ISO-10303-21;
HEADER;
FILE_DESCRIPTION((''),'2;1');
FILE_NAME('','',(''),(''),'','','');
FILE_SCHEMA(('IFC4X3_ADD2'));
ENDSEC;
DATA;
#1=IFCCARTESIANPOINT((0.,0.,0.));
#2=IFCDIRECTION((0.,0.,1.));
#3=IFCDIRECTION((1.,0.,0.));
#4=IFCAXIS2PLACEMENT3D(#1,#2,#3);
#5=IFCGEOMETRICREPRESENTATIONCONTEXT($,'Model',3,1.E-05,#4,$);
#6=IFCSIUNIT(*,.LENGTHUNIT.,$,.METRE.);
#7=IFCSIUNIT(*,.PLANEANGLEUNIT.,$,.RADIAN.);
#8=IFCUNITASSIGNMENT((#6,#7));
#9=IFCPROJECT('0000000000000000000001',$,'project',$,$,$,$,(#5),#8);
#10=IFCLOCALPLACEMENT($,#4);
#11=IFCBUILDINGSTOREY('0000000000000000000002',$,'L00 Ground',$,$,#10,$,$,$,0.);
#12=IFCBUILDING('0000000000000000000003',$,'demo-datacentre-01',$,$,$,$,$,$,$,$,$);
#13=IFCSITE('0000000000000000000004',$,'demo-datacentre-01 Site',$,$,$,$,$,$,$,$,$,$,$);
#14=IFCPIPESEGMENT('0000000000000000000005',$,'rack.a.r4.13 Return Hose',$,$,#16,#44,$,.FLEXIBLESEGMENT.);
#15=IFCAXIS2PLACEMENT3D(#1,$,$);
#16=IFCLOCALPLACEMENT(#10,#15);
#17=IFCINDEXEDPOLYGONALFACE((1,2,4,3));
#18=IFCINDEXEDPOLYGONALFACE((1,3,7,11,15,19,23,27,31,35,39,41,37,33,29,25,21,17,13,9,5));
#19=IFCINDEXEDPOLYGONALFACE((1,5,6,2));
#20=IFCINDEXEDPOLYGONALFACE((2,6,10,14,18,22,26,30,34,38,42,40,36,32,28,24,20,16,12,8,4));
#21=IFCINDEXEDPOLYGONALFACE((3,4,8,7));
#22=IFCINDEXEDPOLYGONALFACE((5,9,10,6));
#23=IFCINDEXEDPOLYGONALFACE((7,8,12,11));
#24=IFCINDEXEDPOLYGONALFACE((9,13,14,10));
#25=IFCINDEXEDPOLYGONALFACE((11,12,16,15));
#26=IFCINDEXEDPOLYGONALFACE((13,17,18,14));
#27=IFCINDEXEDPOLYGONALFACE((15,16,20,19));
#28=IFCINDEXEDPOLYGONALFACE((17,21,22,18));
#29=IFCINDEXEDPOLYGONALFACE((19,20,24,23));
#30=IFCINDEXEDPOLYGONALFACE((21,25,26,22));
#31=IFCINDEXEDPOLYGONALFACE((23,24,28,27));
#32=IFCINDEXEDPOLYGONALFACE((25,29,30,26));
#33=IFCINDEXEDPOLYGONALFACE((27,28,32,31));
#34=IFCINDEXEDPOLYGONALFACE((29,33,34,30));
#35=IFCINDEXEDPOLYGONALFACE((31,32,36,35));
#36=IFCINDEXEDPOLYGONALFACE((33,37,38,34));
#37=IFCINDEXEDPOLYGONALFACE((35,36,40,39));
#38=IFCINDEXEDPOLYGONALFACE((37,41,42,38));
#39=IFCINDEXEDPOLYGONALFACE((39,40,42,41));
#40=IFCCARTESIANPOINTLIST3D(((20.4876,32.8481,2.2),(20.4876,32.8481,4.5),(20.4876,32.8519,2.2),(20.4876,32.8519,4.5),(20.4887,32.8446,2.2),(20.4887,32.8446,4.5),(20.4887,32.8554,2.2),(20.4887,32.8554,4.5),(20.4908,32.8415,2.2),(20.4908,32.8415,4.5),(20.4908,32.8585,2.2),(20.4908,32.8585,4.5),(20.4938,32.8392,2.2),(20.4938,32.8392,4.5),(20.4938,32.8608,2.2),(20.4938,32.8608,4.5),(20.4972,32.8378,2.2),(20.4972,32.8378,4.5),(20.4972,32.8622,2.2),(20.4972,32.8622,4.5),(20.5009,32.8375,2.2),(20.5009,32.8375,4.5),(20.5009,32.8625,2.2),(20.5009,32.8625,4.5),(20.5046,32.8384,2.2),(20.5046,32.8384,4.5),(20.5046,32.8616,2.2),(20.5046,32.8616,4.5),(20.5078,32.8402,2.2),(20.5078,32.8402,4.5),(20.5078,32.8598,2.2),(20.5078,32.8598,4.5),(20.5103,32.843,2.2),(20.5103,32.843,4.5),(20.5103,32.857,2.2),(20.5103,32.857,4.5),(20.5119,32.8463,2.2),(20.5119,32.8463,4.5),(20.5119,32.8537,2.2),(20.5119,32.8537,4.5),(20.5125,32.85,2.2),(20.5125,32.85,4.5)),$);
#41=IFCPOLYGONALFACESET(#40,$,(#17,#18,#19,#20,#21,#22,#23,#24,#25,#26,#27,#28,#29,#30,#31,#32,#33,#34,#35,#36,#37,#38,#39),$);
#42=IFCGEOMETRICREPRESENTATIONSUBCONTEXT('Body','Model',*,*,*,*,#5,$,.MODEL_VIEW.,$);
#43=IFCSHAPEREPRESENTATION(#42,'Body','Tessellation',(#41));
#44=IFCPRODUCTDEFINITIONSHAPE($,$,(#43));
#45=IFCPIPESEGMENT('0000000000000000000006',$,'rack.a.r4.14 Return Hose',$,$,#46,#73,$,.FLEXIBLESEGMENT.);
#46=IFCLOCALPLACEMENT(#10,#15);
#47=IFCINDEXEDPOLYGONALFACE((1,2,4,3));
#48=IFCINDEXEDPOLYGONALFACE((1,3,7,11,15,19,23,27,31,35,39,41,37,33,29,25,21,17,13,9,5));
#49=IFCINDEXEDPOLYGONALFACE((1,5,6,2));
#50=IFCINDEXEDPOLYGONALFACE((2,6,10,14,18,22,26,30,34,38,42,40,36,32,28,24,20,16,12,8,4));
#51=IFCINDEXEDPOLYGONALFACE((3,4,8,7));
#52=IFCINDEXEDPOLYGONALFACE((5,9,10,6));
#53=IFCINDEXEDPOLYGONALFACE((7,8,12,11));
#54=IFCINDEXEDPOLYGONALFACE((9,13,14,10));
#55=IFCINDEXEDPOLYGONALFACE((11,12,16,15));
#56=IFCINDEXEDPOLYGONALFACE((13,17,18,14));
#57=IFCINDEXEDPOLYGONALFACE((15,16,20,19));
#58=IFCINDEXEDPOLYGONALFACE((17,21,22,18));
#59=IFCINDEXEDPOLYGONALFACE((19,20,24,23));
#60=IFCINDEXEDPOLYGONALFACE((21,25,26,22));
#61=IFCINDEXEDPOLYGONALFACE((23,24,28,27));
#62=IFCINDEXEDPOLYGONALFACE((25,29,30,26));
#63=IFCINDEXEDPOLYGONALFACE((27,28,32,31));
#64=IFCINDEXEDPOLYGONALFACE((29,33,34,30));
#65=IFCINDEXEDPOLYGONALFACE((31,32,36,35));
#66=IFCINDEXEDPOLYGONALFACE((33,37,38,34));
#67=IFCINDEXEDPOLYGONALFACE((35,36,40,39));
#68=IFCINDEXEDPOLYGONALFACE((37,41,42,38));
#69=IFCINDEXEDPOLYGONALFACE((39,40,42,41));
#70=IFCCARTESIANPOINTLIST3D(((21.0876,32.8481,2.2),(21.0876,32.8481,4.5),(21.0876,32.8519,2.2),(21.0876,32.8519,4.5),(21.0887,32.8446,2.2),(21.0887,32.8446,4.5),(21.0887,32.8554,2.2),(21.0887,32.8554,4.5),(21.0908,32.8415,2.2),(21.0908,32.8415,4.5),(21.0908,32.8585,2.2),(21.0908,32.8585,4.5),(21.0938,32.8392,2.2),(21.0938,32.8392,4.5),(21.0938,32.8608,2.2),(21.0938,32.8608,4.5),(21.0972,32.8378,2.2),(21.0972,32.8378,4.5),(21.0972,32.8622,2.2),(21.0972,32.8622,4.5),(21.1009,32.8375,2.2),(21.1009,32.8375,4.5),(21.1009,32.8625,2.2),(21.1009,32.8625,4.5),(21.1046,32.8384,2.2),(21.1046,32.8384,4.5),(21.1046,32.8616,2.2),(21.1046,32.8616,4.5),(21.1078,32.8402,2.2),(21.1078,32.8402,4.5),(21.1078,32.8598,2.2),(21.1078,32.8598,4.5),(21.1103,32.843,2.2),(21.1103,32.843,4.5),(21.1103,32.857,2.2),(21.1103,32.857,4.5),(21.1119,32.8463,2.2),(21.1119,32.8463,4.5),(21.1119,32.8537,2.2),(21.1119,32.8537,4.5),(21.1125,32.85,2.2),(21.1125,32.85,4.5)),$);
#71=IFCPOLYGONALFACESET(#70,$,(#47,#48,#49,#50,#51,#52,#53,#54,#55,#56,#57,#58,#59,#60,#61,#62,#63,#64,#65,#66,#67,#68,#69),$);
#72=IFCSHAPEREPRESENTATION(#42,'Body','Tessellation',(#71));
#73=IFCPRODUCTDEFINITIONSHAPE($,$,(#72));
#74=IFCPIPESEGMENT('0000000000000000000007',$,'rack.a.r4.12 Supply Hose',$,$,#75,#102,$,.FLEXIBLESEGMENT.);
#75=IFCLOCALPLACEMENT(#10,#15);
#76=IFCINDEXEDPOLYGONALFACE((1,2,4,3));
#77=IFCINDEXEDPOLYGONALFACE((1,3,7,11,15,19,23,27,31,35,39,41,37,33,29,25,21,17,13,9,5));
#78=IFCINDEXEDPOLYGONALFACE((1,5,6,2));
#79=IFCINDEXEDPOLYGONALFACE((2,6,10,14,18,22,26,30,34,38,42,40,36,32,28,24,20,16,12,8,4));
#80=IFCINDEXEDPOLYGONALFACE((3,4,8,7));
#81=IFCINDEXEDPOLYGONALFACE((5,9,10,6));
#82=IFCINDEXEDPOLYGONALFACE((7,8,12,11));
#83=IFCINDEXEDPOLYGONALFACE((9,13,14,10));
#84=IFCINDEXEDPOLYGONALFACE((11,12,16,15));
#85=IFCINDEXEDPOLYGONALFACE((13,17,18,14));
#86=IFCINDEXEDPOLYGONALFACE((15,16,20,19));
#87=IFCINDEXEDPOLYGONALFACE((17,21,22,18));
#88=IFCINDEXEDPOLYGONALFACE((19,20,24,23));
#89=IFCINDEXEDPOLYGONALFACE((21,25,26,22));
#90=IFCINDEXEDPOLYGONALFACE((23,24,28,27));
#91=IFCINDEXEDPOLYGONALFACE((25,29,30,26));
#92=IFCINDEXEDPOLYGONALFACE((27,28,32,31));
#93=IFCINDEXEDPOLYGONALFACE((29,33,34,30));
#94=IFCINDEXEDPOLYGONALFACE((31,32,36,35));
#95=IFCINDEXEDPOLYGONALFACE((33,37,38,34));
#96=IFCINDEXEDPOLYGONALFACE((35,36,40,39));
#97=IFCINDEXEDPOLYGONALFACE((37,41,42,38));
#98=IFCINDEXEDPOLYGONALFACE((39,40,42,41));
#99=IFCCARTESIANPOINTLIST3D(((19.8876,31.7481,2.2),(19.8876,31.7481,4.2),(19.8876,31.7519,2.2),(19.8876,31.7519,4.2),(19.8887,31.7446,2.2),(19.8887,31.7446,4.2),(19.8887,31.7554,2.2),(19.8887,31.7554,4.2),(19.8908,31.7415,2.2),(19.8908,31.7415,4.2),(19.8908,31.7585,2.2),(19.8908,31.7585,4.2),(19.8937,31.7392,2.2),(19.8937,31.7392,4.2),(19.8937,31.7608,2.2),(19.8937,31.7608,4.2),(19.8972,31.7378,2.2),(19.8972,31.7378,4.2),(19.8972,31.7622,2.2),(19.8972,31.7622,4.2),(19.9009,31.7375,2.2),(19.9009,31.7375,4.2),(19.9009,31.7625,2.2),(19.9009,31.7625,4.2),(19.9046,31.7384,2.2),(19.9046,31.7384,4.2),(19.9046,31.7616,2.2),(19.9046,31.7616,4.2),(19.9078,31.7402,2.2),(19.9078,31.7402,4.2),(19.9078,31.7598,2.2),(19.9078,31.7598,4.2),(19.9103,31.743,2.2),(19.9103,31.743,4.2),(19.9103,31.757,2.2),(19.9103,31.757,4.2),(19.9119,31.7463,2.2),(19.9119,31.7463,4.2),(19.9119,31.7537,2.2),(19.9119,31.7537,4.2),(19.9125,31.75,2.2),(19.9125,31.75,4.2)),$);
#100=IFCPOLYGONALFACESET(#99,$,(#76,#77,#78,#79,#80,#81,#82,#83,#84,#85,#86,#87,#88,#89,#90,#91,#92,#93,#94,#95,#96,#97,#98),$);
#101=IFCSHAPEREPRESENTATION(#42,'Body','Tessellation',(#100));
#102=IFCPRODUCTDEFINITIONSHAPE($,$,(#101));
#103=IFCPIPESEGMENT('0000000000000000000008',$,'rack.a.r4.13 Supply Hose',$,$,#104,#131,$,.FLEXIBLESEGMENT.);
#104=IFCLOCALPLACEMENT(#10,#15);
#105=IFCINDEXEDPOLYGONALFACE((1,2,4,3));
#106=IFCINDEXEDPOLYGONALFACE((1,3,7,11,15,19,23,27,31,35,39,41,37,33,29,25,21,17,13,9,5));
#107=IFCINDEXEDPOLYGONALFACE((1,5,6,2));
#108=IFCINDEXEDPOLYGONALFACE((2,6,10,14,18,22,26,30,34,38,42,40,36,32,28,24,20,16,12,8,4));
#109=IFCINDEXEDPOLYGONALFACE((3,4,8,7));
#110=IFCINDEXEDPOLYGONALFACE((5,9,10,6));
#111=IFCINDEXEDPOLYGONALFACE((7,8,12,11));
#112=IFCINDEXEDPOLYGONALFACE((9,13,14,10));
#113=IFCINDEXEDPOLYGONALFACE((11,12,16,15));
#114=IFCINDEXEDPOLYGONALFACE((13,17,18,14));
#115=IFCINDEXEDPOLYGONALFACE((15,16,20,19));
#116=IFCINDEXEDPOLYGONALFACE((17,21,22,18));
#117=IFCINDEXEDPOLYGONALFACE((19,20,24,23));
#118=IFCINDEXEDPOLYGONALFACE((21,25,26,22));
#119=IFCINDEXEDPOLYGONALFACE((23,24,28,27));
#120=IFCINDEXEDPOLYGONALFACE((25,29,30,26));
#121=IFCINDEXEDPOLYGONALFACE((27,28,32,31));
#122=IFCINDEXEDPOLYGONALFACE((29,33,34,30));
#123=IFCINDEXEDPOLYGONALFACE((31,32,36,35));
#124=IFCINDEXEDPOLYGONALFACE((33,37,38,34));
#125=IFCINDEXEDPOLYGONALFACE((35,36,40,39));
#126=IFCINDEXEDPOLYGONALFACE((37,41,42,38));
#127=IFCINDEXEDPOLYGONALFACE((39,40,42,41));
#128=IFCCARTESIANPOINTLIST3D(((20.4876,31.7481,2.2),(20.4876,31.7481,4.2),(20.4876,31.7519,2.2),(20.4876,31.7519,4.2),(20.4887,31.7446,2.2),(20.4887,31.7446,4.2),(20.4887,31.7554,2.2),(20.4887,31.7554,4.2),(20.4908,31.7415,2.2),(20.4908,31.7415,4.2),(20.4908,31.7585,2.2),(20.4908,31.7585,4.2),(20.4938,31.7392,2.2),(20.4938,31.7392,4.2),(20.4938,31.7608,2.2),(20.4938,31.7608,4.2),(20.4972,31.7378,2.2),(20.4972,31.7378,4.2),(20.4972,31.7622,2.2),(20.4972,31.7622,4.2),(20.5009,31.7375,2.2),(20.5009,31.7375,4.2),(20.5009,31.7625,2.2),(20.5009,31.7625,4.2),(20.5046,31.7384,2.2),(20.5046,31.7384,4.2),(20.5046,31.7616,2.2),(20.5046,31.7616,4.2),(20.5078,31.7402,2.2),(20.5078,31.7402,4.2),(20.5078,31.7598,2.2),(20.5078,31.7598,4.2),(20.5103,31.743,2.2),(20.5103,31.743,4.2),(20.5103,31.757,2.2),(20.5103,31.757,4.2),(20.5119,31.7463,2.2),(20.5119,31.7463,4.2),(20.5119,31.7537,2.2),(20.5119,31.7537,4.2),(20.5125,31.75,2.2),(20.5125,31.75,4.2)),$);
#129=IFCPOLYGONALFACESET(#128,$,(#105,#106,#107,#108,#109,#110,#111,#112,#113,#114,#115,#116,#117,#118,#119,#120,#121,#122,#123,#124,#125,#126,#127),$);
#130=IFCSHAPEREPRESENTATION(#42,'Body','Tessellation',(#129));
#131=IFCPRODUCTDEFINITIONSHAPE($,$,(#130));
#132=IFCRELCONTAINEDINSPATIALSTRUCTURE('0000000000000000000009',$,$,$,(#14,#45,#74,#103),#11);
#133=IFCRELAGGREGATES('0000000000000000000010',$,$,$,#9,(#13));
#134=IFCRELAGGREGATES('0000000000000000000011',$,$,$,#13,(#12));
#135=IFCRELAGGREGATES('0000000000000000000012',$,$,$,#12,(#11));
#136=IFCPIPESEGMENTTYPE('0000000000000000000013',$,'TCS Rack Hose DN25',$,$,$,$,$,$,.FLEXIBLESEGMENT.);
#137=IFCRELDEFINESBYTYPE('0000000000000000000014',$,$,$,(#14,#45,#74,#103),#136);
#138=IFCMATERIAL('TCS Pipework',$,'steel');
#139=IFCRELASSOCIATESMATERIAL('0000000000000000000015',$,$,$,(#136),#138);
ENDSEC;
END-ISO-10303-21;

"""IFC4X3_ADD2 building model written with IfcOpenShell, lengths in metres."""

from ifc_helpers import new_model, si_unit, frame, origin_with_axes, place, context, subcontext, project, spatial, circle, extrude, material, type_object, element, save


model = new_model("IFC4X3_ADD2")

# Units and contexts
model_context = context("Model", 3, precision=1e-05, world=origin_with_axes())
body_context = subcontext(model_context, "Body", "Model", "MODEL_VIEW")
ifc_project = project(units=[si_unit("LENGTHUNIT", "METRE"), si_unit("PLANEANGLEUNIT", "RADIAN")], contexts=[model_context])

# Site, building, storey
site = spatial("IfcSite", under=ifc_project, Name="demo-datacentre-01 Site")
building = spatial("IfcBuilding", under=site, Name="demo-datacentre-01")
storey_placement = place(None, origin_with_axes())
storey = spatial("IfcBuildingStorey", under=building, at=storey_placement, Name="L00 Ground", Elevation=0.0)

# Shared definitions
ifc_material = material(Name="TCS Pipework", Category="steel")

# Pipe segments
pipe_segment_type_1 = type_object("IfcPipeSegmentType", Name="TCS Rack Hose DN25", PredefinedType="FLEXIBLESEGMENT", material=ifc_material)
for number, where, z_axis, x_axis, name in (
    (1, (20.5, 32.85, 4.5), (0.0, 0.0, -1.0), (1.0, 0.0, 0.0), "rack.a.r4.13 Return Hose"),
    (2, (21.1, 32.85, 4.5), (0.0, 0.0, -1.0), (1.0, 0.0, 0.0), "rack.a.r4.14 Return Hose"),
):
    element("IfcPipeSegment", number, at=place(storey_placement, frame(where, z_axis=z_axis, x_axis=x_axis)), inside=storey, type_object=pipe_segment_type_1, Name=name, PredefinedType="FLEXIBLESEGMENT", context=body_context, shape_type="SweptSolid", body=[
        extrude(circle(Radius=0.0125), origin_with_axes(), (0.0, 0.0, 1.0), 2.3),
    ])
for number, where, z_axis, x_axis, name in (
    (3, (19.9, 31.75, 4.2), (0.0, 0.0, -1.0), (1.0, 0.0, 0.0), "rack.a.r4.12 Supply Hose"),
    (4, (20.5, 31.75, 4.2), (0.0, 0.0, -1.0), (1.0, 0.0, 0.0), "rack.a.r4.13 Supply Hose"),
):
    element("IfcPipeSegment", number, at=place(storey_placement, frame(where, z_axis=z_axis, x_axis=x_axis)), inside=storey, type_object=pipe_segment_type_1, Name=name, PredefinedType="FLEXIBLESEGMENT", context=body_context, shape_type="SweptSolid", body=[
        extrude(circle(Radius=0.0125), origin_with_axes(), (0.0, 0.0, 1.0), 2.0),
    ])

save(model, "model.ifc")
